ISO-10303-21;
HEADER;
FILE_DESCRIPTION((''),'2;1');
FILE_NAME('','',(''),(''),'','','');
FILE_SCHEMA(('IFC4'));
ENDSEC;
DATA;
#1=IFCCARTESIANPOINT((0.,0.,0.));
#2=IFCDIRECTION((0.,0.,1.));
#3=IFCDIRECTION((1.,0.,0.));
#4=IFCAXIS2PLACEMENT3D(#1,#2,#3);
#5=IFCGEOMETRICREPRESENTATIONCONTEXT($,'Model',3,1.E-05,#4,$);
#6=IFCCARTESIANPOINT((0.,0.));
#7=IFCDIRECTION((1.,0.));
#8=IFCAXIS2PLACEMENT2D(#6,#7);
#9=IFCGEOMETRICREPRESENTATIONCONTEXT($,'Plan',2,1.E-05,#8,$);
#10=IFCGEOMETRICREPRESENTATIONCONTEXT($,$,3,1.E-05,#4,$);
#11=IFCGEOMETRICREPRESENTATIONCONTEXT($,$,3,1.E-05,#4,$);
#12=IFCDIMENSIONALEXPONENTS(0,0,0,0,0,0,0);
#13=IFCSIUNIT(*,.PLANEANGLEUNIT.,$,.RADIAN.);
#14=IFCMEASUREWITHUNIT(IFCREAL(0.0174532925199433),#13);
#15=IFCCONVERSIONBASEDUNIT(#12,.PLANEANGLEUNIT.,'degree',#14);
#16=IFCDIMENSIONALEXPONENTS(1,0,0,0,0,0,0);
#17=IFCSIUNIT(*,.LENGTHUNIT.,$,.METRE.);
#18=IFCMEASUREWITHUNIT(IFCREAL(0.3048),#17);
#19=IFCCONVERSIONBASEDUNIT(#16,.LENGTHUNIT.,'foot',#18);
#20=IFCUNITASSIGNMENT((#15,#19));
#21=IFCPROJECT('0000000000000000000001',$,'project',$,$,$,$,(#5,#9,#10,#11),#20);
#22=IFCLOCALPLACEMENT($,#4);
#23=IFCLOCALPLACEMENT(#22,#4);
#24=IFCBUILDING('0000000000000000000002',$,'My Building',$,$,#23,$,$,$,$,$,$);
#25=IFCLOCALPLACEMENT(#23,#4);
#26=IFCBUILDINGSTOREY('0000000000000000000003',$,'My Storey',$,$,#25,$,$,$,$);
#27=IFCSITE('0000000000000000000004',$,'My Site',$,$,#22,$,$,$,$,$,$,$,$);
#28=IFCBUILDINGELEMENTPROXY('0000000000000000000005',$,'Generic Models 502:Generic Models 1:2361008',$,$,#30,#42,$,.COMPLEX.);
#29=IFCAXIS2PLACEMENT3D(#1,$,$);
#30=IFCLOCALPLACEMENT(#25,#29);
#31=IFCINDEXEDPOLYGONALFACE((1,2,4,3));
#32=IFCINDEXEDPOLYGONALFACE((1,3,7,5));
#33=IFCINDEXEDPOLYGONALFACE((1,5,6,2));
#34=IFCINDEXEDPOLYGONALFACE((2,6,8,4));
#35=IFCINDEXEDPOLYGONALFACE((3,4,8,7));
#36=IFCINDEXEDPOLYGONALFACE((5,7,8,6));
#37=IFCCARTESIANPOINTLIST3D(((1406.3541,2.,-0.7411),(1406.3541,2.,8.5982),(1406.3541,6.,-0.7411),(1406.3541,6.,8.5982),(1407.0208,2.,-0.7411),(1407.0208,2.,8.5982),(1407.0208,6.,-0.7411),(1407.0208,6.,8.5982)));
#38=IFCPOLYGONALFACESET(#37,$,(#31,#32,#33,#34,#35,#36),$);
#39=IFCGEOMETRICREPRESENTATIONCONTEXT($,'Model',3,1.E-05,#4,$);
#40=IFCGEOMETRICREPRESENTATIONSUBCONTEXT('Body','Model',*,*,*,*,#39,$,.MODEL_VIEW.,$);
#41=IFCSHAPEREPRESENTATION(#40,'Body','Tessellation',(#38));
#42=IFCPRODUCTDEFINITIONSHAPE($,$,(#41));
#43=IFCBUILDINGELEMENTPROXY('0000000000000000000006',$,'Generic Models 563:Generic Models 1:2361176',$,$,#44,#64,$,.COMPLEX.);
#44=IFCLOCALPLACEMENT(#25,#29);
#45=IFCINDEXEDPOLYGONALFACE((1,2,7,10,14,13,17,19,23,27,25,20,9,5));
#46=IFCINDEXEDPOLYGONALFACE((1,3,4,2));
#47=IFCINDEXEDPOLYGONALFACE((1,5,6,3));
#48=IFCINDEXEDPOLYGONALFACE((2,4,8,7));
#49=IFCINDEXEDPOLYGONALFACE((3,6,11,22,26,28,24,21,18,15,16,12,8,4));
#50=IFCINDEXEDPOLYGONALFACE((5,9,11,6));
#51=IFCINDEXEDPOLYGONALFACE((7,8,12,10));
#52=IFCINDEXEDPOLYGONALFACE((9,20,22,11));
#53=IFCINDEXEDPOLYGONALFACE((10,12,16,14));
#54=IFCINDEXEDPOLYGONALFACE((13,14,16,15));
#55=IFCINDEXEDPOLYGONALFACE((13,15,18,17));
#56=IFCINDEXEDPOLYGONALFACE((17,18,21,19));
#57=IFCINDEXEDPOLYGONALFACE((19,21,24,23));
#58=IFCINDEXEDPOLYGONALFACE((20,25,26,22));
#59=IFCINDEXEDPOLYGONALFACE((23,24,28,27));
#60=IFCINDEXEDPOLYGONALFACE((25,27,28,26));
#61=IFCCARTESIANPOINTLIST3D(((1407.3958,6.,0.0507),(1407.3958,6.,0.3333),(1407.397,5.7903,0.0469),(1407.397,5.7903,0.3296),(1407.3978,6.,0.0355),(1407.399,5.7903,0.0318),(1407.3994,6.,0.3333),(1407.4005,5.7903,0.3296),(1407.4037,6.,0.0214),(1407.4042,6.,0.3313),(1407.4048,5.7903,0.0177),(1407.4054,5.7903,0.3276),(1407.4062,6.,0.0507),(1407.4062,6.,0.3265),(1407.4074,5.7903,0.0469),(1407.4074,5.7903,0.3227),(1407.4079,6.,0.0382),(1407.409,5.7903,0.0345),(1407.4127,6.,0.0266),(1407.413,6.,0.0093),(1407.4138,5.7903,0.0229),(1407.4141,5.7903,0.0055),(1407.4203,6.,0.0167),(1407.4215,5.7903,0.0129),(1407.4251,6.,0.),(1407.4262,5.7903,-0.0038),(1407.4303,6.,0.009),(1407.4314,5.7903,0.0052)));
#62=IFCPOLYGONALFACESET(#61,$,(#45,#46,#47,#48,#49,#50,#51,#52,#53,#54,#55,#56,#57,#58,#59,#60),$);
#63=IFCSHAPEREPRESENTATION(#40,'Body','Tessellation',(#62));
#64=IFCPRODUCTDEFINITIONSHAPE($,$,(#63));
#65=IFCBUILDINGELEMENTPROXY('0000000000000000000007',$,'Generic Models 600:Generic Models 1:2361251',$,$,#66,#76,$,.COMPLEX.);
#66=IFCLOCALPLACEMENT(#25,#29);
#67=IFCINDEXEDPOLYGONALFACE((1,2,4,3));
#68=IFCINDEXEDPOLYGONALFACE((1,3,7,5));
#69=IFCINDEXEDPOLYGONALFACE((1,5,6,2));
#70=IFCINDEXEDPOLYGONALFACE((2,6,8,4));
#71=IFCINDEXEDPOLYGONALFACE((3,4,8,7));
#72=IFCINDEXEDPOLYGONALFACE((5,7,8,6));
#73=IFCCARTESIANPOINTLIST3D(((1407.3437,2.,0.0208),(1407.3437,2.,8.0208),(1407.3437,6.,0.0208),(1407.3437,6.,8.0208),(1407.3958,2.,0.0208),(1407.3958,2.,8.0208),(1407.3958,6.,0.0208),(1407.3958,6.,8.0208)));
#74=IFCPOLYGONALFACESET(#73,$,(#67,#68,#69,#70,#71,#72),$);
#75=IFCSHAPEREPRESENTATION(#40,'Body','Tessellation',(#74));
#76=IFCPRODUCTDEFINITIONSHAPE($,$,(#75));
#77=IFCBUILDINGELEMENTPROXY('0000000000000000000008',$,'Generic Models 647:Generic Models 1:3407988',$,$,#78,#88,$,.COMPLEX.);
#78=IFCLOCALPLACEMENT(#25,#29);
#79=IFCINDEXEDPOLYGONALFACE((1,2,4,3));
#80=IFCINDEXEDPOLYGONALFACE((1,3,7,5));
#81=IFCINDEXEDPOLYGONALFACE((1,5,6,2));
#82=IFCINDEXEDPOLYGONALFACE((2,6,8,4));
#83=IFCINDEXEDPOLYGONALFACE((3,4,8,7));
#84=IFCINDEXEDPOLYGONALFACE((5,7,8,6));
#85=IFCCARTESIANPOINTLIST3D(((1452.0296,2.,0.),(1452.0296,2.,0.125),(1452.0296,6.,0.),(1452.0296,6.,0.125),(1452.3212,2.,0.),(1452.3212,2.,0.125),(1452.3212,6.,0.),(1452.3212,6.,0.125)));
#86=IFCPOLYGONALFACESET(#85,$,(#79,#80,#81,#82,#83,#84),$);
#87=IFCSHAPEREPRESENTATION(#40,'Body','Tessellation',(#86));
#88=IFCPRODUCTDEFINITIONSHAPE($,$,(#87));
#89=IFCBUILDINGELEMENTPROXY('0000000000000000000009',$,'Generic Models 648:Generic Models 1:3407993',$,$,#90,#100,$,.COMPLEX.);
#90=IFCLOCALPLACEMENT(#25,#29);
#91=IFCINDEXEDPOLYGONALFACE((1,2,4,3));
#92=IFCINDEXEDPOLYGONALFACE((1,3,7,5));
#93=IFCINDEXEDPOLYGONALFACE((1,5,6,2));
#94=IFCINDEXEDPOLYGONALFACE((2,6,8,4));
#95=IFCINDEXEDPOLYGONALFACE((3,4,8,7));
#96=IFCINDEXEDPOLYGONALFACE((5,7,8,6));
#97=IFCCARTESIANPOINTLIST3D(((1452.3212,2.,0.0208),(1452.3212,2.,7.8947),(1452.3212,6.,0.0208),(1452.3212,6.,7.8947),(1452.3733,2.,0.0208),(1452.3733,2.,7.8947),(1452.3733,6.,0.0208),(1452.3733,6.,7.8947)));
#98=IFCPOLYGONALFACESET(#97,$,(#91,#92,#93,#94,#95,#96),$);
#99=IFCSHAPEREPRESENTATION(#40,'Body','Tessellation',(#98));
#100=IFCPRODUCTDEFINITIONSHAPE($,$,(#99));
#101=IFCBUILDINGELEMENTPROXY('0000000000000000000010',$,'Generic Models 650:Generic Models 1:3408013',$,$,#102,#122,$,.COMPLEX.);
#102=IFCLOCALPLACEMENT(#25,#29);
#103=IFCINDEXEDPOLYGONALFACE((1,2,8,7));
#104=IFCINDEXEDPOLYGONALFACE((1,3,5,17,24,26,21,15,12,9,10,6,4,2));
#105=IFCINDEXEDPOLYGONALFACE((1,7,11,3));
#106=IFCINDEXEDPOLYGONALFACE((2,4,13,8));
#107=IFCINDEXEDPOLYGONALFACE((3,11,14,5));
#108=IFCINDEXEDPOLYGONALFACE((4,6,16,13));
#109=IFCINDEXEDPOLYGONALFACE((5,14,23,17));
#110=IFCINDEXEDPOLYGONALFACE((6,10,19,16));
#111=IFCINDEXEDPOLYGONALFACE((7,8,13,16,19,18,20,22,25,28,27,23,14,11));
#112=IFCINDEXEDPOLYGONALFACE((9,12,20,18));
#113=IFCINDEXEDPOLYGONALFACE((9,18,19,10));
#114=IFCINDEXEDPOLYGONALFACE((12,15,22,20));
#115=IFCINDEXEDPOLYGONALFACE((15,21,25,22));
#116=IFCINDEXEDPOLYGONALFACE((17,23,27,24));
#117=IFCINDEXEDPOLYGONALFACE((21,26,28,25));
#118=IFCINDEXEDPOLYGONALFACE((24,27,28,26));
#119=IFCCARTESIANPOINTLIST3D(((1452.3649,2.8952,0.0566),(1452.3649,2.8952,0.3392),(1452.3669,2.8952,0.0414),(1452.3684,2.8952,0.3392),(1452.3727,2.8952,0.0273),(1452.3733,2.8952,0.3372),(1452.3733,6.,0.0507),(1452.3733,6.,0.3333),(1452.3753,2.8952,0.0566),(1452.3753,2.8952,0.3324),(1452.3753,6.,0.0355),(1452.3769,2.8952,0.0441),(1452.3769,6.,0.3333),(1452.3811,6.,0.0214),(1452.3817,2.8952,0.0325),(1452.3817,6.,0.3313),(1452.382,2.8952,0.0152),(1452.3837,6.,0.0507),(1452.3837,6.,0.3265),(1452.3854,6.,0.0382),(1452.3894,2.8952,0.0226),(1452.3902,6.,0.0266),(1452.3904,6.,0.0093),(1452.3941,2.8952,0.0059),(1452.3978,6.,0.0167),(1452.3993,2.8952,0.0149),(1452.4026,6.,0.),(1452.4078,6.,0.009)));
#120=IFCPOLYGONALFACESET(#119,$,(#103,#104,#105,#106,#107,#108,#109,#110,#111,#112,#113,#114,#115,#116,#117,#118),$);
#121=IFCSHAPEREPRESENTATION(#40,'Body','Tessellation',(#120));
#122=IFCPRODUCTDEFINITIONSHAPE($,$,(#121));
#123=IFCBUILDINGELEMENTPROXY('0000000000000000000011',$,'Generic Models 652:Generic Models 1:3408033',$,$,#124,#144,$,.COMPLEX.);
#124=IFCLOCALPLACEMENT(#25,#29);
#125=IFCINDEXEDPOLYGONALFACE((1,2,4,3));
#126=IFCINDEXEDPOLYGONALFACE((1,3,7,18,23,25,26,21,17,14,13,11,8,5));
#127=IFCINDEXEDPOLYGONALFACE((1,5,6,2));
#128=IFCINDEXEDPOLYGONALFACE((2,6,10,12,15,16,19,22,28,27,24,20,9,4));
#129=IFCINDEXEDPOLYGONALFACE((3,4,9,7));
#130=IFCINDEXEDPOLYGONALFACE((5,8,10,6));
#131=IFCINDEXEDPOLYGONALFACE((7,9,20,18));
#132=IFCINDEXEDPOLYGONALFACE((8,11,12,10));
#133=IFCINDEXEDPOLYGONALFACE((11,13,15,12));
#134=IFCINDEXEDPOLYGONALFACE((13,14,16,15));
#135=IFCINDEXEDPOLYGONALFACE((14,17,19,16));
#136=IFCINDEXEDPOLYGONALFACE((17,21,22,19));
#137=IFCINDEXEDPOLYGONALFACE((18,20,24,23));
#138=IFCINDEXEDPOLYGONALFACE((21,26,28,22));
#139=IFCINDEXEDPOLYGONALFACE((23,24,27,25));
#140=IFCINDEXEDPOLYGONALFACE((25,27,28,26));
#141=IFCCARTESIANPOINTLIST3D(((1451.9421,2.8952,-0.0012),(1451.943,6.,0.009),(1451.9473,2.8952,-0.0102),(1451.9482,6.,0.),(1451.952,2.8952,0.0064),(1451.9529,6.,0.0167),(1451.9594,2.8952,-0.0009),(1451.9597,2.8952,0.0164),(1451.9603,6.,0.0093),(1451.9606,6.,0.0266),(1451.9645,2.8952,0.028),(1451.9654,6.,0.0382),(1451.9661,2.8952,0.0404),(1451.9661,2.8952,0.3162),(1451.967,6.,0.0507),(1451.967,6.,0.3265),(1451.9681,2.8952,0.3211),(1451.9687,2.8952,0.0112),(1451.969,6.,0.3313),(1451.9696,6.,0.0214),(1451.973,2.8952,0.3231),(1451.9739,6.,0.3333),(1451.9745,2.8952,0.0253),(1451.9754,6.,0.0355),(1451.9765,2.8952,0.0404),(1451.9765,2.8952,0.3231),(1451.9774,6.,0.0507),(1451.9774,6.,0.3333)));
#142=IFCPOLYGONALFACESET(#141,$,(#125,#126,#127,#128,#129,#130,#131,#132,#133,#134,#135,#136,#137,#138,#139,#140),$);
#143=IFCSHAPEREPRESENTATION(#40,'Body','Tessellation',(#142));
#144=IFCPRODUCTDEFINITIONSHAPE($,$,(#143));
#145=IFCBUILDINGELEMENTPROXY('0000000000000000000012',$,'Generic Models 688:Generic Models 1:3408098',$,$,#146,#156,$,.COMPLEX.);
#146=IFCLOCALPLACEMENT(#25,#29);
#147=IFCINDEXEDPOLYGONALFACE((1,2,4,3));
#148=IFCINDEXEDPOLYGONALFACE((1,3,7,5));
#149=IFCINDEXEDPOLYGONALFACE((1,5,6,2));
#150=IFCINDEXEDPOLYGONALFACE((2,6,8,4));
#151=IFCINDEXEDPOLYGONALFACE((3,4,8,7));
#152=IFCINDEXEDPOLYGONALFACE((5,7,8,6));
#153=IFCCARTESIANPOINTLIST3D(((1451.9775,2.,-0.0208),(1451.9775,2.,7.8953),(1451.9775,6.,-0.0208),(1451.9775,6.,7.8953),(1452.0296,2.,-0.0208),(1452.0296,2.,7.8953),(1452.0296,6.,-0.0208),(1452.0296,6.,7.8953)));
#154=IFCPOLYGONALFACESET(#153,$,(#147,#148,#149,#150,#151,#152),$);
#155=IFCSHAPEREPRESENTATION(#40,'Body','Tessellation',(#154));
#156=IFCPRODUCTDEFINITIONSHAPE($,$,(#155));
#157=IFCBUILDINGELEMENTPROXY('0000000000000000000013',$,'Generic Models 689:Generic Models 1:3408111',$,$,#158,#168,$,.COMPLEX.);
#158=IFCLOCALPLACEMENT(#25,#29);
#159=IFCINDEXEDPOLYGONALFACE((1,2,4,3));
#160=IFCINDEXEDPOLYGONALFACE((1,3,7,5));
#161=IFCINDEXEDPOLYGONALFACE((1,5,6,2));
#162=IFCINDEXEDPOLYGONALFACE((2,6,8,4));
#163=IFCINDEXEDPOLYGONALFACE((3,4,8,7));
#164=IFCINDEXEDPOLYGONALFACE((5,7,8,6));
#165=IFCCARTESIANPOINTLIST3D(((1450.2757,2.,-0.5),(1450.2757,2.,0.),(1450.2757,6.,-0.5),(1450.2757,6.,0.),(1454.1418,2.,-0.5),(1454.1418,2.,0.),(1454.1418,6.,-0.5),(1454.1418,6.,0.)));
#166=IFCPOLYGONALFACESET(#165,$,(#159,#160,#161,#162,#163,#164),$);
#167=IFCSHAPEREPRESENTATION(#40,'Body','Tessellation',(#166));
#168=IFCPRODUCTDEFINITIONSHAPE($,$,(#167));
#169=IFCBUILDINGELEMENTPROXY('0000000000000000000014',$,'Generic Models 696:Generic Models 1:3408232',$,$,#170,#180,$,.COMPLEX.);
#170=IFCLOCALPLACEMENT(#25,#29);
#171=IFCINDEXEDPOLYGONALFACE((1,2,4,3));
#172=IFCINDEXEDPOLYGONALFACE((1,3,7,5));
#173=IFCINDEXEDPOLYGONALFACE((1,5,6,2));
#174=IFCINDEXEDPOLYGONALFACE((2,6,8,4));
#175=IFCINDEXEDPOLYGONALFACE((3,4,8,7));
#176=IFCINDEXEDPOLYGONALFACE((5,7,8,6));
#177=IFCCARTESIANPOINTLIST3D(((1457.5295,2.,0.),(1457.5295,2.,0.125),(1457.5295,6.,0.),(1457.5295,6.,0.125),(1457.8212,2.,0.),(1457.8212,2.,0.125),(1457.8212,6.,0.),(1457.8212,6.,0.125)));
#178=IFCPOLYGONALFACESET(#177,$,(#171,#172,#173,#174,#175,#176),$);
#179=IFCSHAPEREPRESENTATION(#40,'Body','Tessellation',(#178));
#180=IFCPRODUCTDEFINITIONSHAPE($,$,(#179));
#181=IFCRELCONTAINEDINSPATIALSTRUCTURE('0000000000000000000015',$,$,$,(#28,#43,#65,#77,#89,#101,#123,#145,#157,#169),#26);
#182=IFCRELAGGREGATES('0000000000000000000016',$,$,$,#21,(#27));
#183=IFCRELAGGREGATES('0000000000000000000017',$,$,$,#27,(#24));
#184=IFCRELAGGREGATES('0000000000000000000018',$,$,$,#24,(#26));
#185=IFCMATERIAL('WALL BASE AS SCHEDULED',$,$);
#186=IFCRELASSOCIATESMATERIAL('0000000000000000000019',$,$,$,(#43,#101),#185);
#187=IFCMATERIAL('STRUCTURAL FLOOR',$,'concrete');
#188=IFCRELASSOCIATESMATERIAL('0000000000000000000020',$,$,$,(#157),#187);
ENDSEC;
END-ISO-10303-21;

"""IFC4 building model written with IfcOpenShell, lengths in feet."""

from ifc_helpers import new_model, entity, si_unit, converted_unit, frame, origin_with_axes, origin_2d_with_axis, place, context, subcontext, project, spatial, polyline, line, indexed_curve, outline, extrude, material, element, save


model = new_model("IFC4")

# Units and contexts
model_context_1 = context("Model", 3, precision=1e-05, world=origin_with_axes())
plan_context = context("Plan", 2, precision=1e-05, world=origin_2d_with_axis())
model_context_2 = context("Model", 3, precision=1e-05, world=origin_with_axes())
context_of_model_1 = context(None, 3, precision=1e-05, world=origin_with_axes())
context_of_model_2 = context(None, 3, precision=1e-05, world=origin_with_axes())
body_context = subcontext(model_context_2, "Body", "Model", "MODEL_VIEW")
ifc_project = project(units=[converted_unit("PLANEANGLEUNIT", "degree", entity("IfcReal", 0.0174532925199433), si_unit("PLANEANGLEUNIT", "RADIAN"), dimensions=[0, 0, 0, 0, 0, 0, 0]), converted_unit("LENGTHUNIT", "foot", entity("IfcReal", 0.3048), si_unit("LENGTHUNIT", "METRE"), dimensions=[1, 0, 0, 0, 0, 0, 0])], contexts=[model_context_1, plan_context, context_of_model_1, context_of_model_2])

# Site, building, storey
site_placement = place(None, origin_with_axes())
site = spatial("IfcSite", under=ifc_project, at=site_placement, Name="My Site")
building_placement = place(site_placement, origin_with_axes())
building = spatial("IfcBuilding", under=site, at=building_placement, Name="My Building")
storey_placement = place(building_placement, origin_with_axes())
storey = spatial("IfcBuildingStorey", under=building, at=storey_placement, Name="My Storey")

# Building element proxies
proxy_1_placement = place(storey_placement, frame((1406.3541, 6.0, -0.7411), z_axis=(0.0, -1.0, 0.0), x_axis=(0.0, 0.0, 1.0)))
element("IfcBuildingElementProxy", 1, at=proxy_1_placement, inside=storey, Name="Generic Models 502:Generic Models 1:2361008", PredefinedType="COMPLEX", context=body_context, shape_type="SweptSolid", body=[
    extrude(outline(indexed_curve([(-0.3333, -4.6697), (0.3333, -4.6697), (0.3333, 4.6697), (-0.3333, 4.6697)], segments=[line(4, 1), line(1, 2), line(2, 3), line(3, 4)], self_intersect=False)), frame((4.6697, -0.3333, 0.0), z_axis=(0.0, 0.0, -1.0), x_axis=(0.0, 1.0, 0.0)), (0.0, 0.0, -1.0), 4.0),
])
ifc_material_1 = material(Name="WALL BASE AS SCHEDULED")
proxy_2_placement = place(storey_placement, frame((1407.3958, 6.0, 0.0), z_axis=(0.0, -1.0, 0.0), x_axis=(0.0, 0.0, 1.0)))
element("IfcBuildingElementProxy", 2, at=proxy_2_placement, inside=storey, material=ifc_material_1, Name="Generic Models 563:Generic Models 1:2361176", PredefinedType="COMPLEX", context=body_context, shape_type="SweptSolid", body=[
    extrude(outline(polyline([(0.0971, 0.0), (0.1059, -0.009), (0.1142, -0.0027), (0.1035, 0.0082), (0.0904, 0.016), (0.0756, 0.02), (0.0603, 0.0202), (-0.2202, -0.0144), (-0.2197, -0.0179), (-0.2172, -0.0225), (-0.2121, -0.0239), (0.0616, 0.0098), (0.0742, 0.0097), (0.0863, 0.0064), (0.0971, 0.0)])), frame((0.113, -0.0126, 0.0), z_axis=(0.0, 0.0, -1.0), x_axis=(-0.992503, -0.12222, 0.0)), (0.01852, -0.003236, -0.999823), 0.2098),
])
proxy_3_placement = place(storey_placement, frame((1407.3437, 6.0, 0.0208), z_axis=(0.0, -1.0, 0.0), x_axis=(0.0, 0.0, 1.0)))
element("IfcBuildingElementProxy", 3, at=proxy_3_placement, inside=storey, Name="Generic Models 600:Generic Models 1:2361251", PredefinedType="COMPLEX", context=body_context, shape_type="SweptSolid", body=[
    extrude(outline(polyline([(-4.0, -0.026), (4.0, -0.026), (4.0, 0.026), (-4.0, 0.026), (-4.0, -0.026)])), frame((4.0, -0.026, 0.0), z_axis=(0.0, 0.0, -1.0), x_axis=(1.0, 0.0, 0.0)), (0.0, 0.0, -1.0), 4.0),
])
proxy_4_placement = place(storey_placement, frame((1452.0296, 6.0, 0.0), z_axis=(0.0, -1.0, 0.0), x_axis=(0.0, 0.0, 1.0)))
element("IfcBuildingElementProxy", 4, at=proxy_4_placement, inside=storey, Name="Generic Models 647:Generic Models 1:3407988", PredefinedType="COMPLEX", context=body_context, shape_type="SweptSolid", body=[
    extrude(outline(polyline([(-0.0625, -0.1458), (0.0625, -0.1458), (0.0625, 0.1458), (-0.0625, 0.1458), (-0.0625, -0.1458)])), frame((0.0625, -0.1458, 0.0), z_axis=(0.0, 0.0, -1.0), x_axis=(1.0, 0.0, 0.0)), (0.0, 0.0, -1.0), 4.0),
])
proxy_5_placement = place(storey_placement, frame((1452.3212, 6.0, 0.0208), z_axis=(0.0, -1.0, 0.0), x_axis=(0.0, 0.0, 1.0)))
element("IfcBuildingElementProxy", 5, at=proxy_5_placement, inside=storey, Name="Generic Models 648:Generic Models 1:3407993", PredefinedType="COMPLEX", context=body_context, shape_type="SweptSolid", body=[
    extrude(outline(polyline([(-3.9369, -0.026), (3.9369, -0.026), (3.9369, 0.026), (-3.9369, 0.026), (-3.9369, -0.026)])), frame((3.9369, -0.026, 0.0), z_axis=(0.0, 0.0, -1.0), x_axis=(1.0, 0.0, 0.0)), (0.0, 0.0, -1.0), 4.0),
])
proxy_6_placement = place(storey_placement, frame((1452.3733, 6.0, 0.0), z_axis=(0.0, -1.0, 0.0), x_axis=(0.0, 0.0, 1.0)))
element("IfcBuildingElementProxy", 6, at=proxy_6_placement, inside=storey, material=ifc_material_1, Name="Generic Models 650:Generic Models 1:3408013", PredefinedType="COMPLEX", context=body_context, shape_type="SweptSolid", body=[
    extrude(outline(polyline([(0.2206, 0.0), (0.2204, 0.0036), (0.2182, 0.0083), (0.2132, 0.01), (-0.0621, -0.0058), (-0.0747, -0.0049), (-0.0865, -0.0007), (-0.0969, 0.0063), (-0.1051, 0.0158), (-0.1138, 0.0101), (-0.1038, -0.0014), (-0.0912, -0.01), (-0.0768, -0.0151), (-0.0615, -0.0162), (0.2206, 0.0)])), frame((0.113, -0.0126, 0.0), z_axis=(0.0, 0.0, -1.0), x_axis=(0.998358, 0.057286, 0.0)), (0.002054, -0.002598, -0.999995), 3.1048),
])
proxy_7_placement = place(storey_placement, frame((1451.943, 6.0, 0.0), z_axis=(0.0, -1.0, 0.0), x_axis=(0.0, 0.0, 1.0)))
element("IfcBuildingElementProxy", 7, at=proxy_7_placement, inside=storey, Name="Generic Models 652:Generic Models 1:3408033", PredefinedType="COMPLEX", context=body_context, shape_type="SweptSolid", body=[
    extrude(outline(polyline([(-0.0624, 0.0022), (0.2134, 0.0022), (0.2183, 0.0042), (0.2203, 0.0091), (0.2203, 0.0126), (-0.0624, 0.0126), (-0.0775, 0.0106), (-0.0916, 0.0048), (-0.1037, -0.0045), (-0.113, -0.0166), (-0.104, -0.0218), (-0.0964, -0.0119), (-0.0864, -0.0042), (-0.0748, 0.0006), (-0.0624, 0.0022)])), frame((0.113, -0.0218, 0.0), z_axis=(0.0, 0.0, -1.0), x_axis=(1.0, 0.0, 0.0)), (-0.003299, -0.000291, -0.999995), 3.1048),
])
proxy_8_placement = place(storey_placement, frame((1451.9775, 6.0, -0.0208), z_axis=(0.0, -1.0, 0.0), x_axis=(0.0, 0.0, 1.0)))
element("IfcBuildingElementProxy", 8, at=proxy_8_placement, inside=storey, Name="Generic Models 688:Generic Models 1:3408098", PredefinedType="COMPLEX", context=body_context, shape_type="SweptSolid", body=[
    extrude(outline(polyline([(-3.9581, -0.026), (3.9581, -0.026), (3.9581, 0.026), (-3.9581, 0.026), (-3.9581, -0.026)])), frame((3.9581, -0.026, 0.0), z_axis=(0.0, 0.0, -1.0), x_axis=(1.0, 0.0, 0.0)), (0.0, 0.0, -1.0), 4.0),
])
ifc_material_2 = material(Name="STRUCTURAL FLOOR", Category="concrete")
proxy_9_placement = place(storey_placement, frame((1450.2757, 6.0, -0.5), z_axis=(0.0, -1.0, 0.0), x_axis=(0.0, 0.0, 1.0)))
element("IfcBuildingElementProxy", 9, at=proxy_9_placement, inside=storey, material=ifc_material_2, Name="Generic Models 689:Generic Models 1:3408111", PredefinedType="COMPLEX", context=body_context, shape_type="SweptSolid", body=[
    extrude(outline(polyline([(-0.25, -1.9331), (0.25, -1.9331), (0.25, 1.9331), (-0.25, 1.9331), (-0.25, -1.9331)])), frame((0.25, -1.9331, 0.0), z_axis=(0.0, 0.0, -1.0), x_axis=(1.0, 0.0, 0.0)), (0.0, 0.0, -1.0), 4.0),
])
proxy_10_placement = place(storey_placement, frame((1457.5295, 6.0, 0.0), z_axis=(0.0, -1.0, 0.0), x_axis=(0.0, 0.0, 1.0)))
element("IfcBuildingElementProxy", 10, at=proxy_10_placement, inside=storey, Name="Generic Models 696:Generic Models 1:3408232", PredefinedType="COMPLEX", context=body_context, shape_type="SweptSolid", body=[
    extrude(outline(polyline([(-0.0625, -0.1458), (0.0625, -0.1458), (0.0625, 0.1458), (-0.0625, 0.1458), (-0.0625, -0.1458)])), frame((0.0625, -0.1458, 0.0), z_axis=(0.0, 0.0, -1.0), x_axis=(1.0, 0.0, 0.0)), (0.0, 0.0, -1.0), 4.0),
])

save(model, "model.ifc")
